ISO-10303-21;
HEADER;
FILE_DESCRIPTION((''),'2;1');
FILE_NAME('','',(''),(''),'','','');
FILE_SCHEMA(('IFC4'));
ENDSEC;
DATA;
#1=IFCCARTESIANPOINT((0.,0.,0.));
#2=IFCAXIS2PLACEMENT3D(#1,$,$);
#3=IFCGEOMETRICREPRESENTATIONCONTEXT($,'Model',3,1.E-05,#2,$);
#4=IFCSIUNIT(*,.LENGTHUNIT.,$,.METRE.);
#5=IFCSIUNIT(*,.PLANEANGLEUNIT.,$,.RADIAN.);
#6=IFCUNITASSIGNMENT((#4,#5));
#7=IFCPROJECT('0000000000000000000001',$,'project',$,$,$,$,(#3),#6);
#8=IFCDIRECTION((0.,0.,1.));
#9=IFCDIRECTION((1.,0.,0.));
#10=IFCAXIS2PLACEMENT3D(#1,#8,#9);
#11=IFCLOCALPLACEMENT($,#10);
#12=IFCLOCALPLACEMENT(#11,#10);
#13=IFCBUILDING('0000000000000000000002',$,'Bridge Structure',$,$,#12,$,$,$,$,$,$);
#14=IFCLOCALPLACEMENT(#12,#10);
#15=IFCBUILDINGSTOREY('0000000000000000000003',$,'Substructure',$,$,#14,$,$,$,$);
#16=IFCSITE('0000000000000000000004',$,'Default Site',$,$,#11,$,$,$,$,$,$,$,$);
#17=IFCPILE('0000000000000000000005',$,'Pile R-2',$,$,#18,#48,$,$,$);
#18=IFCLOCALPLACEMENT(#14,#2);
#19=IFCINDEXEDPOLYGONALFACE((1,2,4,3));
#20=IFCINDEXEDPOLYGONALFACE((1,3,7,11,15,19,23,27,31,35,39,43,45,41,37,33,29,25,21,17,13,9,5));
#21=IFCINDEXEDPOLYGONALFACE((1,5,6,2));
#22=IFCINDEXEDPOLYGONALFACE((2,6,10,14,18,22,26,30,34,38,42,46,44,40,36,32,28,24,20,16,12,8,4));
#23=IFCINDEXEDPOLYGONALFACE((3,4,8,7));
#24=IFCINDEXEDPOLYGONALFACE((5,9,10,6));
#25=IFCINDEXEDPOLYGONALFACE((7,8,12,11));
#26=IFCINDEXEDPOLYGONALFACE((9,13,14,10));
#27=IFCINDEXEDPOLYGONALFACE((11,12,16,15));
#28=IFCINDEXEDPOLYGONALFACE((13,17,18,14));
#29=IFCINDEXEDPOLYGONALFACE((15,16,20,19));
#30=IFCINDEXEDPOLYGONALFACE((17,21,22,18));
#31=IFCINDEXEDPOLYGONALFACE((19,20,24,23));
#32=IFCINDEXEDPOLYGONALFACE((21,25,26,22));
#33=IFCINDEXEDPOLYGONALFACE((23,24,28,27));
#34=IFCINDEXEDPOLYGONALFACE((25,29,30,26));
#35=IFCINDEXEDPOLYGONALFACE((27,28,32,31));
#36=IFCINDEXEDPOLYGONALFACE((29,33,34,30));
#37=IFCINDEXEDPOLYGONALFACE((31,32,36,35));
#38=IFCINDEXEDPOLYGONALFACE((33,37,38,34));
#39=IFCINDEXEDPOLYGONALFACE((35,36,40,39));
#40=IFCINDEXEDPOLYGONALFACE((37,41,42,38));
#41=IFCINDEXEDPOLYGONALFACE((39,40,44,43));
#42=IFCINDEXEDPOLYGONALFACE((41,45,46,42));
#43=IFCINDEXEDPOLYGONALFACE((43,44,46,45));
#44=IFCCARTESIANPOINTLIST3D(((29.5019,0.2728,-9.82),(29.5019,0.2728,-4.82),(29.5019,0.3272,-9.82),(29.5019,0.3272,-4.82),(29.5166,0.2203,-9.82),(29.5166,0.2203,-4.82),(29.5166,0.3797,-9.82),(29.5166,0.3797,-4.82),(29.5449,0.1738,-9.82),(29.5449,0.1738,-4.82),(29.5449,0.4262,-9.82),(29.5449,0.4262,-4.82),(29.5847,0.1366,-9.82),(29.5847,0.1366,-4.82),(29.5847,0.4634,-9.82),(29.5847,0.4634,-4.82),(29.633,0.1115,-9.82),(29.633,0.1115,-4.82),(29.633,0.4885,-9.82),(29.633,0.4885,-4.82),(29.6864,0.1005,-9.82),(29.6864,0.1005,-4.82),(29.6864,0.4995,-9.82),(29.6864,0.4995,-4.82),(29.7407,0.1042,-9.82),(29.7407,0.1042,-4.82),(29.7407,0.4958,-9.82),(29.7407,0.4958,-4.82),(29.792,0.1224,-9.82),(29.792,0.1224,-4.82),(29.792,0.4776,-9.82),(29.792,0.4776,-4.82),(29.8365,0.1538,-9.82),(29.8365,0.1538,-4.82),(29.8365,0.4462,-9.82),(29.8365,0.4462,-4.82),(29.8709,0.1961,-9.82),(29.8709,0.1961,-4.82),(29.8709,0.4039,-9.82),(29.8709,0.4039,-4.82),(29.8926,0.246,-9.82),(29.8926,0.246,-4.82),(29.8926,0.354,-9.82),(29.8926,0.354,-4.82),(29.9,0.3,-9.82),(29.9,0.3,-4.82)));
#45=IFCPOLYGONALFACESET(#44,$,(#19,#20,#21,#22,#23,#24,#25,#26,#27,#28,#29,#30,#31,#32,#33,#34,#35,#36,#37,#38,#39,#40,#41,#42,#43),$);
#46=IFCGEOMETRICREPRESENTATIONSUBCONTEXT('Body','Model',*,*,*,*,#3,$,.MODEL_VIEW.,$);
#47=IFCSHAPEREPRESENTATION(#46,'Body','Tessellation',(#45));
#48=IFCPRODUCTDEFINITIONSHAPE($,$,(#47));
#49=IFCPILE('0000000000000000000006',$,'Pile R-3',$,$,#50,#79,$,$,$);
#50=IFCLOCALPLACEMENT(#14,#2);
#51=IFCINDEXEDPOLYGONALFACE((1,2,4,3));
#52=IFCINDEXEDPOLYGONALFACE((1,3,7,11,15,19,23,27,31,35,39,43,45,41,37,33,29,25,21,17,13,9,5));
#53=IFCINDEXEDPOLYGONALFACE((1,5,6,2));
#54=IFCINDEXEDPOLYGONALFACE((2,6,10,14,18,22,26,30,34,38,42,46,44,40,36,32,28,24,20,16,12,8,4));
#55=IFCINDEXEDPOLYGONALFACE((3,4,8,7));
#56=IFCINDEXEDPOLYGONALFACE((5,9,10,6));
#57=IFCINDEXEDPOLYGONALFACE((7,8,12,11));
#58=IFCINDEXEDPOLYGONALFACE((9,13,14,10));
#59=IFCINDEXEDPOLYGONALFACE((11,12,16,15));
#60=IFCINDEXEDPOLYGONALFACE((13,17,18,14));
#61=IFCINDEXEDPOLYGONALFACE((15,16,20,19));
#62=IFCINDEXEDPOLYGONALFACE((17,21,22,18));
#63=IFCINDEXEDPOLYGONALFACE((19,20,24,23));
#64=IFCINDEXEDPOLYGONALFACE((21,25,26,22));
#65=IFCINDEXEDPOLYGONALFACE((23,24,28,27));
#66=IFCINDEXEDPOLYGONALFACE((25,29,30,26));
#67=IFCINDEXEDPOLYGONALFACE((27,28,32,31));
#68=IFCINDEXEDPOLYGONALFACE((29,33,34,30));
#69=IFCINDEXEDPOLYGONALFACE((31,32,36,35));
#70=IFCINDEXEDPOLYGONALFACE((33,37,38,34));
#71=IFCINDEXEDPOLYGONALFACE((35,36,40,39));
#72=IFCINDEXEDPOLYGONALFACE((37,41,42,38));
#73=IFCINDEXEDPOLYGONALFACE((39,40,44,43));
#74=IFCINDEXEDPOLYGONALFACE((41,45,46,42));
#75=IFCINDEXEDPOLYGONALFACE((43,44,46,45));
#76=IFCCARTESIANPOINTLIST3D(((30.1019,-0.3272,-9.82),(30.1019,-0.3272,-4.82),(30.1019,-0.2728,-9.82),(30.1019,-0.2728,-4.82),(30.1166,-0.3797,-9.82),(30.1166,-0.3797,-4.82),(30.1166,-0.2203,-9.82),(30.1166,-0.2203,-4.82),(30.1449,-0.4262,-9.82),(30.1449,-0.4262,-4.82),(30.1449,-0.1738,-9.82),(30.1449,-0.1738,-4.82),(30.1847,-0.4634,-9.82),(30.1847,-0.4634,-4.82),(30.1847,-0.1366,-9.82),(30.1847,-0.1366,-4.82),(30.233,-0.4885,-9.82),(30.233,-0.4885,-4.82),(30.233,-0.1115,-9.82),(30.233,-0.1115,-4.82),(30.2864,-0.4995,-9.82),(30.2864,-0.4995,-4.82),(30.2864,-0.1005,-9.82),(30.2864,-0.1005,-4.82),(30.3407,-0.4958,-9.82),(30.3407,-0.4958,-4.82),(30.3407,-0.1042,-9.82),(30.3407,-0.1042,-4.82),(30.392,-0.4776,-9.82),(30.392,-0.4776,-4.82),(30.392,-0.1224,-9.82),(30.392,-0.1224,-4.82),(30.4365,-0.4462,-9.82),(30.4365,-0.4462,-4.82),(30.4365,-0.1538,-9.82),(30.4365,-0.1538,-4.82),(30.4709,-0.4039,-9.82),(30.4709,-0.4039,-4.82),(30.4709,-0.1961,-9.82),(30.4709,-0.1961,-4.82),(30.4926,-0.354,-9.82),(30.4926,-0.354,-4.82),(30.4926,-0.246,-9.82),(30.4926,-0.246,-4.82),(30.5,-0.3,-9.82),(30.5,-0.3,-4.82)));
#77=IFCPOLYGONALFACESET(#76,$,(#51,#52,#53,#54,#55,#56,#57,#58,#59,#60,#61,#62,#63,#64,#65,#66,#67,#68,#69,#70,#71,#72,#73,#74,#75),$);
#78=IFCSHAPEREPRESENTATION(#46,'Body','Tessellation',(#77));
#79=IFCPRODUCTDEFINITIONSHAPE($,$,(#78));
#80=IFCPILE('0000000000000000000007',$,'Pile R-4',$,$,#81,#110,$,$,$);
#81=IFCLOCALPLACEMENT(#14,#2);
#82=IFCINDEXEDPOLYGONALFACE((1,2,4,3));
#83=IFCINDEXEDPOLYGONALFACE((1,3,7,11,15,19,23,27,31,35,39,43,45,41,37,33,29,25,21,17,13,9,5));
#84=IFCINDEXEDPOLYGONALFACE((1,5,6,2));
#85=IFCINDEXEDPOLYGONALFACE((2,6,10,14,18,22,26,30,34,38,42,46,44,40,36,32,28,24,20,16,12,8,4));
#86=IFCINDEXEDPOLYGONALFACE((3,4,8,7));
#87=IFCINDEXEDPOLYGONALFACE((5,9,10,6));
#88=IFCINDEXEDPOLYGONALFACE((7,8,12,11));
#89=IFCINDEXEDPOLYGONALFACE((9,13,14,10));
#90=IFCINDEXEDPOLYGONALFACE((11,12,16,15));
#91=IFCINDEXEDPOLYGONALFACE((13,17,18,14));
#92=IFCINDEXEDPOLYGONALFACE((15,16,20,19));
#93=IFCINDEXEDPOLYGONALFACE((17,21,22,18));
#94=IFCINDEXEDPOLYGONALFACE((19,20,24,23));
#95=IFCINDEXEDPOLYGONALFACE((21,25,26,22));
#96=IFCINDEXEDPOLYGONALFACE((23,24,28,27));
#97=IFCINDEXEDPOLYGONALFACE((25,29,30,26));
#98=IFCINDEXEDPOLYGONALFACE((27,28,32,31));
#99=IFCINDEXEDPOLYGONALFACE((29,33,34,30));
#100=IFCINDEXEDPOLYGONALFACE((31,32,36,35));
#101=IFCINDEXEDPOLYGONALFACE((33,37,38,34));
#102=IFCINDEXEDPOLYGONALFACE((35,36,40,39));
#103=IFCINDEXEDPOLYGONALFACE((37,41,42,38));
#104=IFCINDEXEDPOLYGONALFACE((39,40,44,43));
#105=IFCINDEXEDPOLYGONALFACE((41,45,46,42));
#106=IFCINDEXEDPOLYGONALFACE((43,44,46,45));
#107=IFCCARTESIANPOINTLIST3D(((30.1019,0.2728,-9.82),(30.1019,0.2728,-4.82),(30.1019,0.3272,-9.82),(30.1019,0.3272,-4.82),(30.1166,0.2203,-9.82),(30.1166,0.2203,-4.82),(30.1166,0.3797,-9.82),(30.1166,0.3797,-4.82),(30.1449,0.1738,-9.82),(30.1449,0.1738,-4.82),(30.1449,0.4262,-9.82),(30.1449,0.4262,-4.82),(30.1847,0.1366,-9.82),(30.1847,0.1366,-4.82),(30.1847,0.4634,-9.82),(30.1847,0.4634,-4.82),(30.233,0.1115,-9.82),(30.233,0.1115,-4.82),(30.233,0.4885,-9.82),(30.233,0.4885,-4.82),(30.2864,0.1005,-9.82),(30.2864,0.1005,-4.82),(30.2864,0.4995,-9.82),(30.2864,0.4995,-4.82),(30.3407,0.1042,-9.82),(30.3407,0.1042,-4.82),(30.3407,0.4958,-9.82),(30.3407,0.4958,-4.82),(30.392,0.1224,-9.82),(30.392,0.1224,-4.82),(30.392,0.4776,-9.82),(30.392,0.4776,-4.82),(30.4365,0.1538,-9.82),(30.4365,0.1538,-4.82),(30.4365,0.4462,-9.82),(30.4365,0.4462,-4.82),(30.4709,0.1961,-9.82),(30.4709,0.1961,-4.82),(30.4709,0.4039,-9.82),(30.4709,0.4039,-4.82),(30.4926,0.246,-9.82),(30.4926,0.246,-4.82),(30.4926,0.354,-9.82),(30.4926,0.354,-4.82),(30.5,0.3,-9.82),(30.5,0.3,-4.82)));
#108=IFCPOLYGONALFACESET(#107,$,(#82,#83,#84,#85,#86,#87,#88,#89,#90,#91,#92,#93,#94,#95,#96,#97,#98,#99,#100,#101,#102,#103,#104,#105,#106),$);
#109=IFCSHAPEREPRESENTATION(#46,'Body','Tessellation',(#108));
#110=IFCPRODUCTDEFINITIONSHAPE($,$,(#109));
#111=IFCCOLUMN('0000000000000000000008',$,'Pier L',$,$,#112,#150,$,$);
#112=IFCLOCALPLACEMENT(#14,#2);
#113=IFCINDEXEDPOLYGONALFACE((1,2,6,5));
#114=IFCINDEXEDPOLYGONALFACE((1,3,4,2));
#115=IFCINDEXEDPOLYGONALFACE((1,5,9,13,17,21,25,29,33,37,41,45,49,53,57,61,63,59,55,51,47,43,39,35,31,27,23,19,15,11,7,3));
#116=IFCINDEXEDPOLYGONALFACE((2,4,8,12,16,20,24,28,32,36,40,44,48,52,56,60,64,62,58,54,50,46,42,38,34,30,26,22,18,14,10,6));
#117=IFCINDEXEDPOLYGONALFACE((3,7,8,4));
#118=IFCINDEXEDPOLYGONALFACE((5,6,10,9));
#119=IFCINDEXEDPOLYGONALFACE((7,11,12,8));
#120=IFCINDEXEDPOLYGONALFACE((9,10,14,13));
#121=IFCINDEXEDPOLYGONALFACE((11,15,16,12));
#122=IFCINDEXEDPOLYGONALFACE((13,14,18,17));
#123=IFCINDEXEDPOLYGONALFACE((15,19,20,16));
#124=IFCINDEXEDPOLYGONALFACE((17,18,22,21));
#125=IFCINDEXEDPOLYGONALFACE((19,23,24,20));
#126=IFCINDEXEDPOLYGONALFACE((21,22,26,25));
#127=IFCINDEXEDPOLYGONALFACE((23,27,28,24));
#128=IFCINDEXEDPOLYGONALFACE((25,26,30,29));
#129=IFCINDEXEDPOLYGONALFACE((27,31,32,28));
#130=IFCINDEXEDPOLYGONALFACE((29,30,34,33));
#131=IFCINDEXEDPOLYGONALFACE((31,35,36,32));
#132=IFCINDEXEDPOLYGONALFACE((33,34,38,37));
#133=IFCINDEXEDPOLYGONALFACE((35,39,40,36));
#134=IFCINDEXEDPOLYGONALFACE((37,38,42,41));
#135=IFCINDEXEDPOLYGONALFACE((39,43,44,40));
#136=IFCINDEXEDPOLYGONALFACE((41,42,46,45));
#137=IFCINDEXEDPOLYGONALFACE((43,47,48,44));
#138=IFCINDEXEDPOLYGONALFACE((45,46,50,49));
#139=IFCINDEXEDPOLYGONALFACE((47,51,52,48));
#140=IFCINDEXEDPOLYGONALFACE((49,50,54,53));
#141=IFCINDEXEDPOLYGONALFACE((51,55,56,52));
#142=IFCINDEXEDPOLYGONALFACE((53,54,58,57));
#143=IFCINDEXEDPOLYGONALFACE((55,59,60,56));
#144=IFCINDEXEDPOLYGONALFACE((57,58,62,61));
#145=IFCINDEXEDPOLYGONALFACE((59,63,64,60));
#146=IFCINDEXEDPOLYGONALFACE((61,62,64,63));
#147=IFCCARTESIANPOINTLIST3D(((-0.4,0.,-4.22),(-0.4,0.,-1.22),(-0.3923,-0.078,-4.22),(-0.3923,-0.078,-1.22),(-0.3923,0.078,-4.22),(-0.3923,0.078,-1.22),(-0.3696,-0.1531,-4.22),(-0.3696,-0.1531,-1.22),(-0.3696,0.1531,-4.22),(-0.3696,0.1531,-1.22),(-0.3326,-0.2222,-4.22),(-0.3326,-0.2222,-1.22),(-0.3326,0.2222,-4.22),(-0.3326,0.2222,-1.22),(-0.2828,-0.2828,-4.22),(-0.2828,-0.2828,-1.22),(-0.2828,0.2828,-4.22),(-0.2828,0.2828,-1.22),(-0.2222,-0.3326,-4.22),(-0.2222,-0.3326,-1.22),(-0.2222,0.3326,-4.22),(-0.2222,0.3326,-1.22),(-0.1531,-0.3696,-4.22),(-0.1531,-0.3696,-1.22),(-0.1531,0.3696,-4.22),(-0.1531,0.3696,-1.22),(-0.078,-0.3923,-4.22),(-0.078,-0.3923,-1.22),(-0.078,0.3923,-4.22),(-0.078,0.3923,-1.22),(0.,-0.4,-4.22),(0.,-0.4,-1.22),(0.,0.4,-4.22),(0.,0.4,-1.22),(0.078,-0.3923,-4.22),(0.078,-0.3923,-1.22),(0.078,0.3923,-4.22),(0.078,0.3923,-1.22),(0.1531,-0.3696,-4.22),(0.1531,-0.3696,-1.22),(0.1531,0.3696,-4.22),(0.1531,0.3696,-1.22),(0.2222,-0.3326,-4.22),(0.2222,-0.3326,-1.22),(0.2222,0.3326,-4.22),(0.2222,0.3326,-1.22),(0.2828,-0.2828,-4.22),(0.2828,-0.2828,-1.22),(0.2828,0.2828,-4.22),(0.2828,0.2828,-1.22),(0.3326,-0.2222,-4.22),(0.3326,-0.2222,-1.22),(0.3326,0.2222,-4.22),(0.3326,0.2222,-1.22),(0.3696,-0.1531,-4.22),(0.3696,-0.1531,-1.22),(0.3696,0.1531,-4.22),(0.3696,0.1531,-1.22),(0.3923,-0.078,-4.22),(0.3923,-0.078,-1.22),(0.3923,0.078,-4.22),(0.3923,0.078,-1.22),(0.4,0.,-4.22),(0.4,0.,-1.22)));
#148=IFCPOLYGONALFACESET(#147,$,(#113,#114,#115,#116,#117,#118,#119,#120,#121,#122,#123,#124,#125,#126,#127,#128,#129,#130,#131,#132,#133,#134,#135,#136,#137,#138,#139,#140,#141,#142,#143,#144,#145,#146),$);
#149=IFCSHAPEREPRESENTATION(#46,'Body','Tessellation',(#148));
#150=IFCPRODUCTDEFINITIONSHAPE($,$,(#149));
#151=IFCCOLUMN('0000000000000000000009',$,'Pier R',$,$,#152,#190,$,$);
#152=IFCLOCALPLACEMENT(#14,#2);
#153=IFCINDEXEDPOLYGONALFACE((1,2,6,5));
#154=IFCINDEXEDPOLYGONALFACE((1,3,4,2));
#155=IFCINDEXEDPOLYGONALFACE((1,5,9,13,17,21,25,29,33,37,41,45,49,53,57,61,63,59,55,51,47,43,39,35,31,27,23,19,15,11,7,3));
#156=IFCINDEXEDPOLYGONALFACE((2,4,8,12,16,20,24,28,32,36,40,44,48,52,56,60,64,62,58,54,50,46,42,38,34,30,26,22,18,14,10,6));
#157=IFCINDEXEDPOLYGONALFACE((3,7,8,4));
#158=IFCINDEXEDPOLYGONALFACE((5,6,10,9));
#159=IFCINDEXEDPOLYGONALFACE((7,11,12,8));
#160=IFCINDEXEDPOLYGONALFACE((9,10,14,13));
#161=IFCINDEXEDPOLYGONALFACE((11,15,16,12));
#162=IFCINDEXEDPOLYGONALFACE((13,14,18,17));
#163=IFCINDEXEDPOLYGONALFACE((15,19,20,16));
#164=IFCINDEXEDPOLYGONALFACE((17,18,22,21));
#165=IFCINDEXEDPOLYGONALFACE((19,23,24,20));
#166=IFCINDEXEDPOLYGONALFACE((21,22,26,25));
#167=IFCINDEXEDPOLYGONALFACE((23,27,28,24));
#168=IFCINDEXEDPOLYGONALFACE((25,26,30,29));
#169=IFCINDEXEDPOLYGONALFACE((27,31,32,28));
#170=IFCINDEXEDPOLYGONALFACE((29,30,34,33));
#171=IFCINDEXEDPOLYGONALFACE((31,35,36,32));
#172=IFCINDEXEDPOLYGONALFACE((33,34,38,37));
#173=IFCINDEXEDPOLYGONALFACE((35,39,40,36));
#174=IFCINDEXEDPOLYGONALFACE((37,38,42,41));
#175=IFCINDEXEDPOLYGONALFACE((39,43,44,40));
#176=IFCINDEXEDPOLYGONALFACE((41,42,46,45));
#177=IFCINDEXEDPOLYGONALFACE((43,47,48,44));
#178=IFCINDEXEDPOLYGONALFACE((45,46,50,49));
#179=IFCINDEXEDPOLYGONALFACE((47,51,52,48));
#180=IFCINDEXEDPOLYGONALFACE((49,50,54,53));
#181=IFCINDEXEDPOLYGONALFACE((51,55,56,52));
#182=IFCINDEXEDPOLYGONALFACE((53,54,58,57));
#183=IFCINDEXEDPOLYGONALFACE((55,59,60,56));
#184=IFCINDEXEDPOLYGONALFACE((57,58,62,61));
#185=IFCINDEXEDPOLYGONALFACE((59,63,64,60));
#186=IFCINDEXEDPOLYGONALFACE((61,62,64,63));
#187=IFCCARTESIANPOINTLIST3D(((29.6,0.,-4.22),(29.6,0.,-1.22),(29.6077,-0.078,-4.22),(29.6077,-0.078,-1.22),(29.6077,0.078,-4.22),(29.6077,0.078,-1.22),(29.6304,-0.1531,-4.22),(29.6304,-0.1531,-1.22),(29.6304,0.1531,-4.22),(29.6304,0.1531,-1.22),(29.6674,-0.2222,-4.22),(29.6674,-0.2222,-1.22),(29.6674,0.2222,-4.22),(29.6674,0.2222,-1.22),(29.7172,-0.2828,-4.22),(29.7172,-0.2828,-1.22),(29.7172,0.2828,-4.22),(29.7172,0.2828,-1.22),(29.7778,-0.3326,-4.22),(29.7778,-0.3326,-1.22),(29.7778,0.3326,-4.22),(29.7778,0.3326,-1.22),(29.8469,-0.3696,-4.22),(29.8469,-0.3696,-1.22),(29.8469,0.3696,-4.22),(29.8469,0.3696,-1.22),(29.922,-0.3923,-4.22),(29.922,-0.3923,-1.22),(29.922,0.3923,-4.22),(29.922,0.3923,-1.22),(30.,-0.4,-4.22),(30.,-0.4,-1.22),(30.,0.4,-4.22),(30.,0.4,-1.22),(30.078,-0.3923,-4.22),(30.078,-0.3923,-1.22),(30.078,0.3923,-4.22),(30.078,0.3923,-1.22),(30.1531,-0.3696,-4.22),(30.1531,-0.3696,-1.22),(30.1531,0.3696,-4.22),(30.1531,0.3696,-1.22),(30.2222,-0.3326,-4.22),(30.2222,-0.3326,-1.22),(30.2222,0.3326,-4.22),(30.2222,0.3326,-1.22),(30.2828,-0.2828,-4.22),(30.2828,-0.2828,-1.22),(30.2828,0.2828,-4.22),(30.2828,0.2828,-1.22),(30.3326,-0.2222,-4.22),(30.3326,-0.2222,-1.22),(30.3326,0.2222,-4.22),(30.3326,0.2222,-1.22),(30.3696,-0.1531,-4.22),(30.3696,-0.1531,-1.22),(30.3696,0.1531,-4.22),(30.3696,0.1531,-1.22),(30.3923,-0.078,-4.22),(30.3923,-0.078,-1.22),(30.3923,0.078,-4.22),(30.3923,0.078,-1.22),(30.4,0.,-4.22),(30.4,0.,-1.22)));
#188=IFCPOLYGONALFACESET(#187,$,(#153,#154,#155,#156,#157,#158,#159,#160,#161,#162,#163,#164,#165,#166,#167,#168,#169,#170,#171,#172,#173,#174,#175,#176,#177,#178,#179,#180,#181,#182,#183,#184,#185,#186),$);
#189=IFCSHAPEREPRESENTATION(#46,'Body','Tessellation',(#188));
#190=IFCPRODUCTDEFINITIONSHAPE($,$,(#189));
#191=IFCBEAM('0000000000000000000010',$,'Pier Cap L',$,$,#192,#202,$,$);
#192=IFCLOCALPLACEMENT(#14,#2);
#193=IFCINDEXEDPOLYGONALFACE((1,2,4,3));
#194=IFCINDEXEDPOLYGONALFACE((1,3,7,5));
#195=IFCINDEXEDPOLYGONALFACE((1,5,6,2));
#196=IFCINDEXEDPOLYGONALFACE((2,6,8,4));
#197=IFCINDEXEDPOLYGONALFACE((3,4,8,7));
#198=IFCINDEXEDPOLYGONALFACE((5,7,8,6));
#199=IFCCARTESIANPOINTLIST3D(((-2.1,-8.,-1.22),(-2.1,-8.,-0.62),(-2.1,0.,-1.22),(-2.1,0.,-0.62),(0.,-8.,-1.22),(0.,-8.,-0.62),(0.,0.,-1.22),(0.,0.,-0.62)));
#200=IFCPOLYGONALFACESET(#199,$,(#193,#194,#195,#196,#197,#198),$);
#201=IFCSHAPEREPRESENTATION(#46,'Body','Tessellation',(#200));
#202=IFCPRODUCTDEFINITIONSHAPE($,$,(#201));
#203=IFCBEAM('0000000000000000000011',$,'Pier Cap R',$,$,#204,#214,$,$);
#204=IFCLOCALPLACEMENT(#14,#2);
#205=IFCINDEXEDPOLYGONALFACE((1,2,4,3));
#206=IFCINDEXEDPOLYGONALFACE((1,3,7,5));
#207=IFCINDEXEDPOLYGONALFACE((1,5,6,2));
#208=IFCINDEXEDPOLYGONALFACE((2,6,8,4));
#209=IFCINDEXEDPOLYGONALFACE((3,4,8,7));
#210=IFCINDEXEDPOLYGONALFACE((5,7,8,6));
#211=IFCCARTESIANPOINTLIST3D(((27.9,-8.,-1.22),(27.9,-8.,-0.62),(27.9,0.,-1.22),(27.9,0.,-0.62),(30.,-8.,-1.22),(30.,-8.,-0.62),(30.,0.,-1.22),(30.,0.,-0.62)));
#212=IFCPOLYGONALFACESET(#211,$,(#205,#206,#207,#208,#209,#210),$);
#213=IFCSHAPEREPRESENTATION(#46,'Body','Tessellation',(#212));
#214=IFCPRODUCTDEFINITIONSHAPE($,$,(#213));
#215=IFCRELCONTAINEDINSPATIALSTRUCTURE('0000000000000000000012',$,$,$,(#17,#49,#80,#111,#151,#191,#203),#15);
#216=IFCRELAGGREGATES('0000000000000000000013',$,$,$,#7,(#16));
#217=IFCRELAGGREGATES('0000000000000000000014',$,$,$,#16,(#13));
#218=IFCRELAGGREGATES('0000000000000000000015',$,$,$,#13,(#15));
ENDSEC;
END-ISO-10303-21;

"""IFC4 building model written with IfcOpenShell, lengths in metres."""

from ifc_helpers import new_model, si_unit, frame, origin, origin_with_axes, origin_2d_with_axis, place, context, subcontext, project, spatial, rectangle, circle, extrude, element, save


model = new_model("IFC4")

# Units and contexts
model_context = context("Model", 3, precision=1e-05, world=origin())
body_context = subcontext(model_context, "Body", "Model", "MODEL_VIEW")
ifc_project = project(units=[si_unit("LENGTHUNIT", "METRE"), si_unit("PLANEANGLEUNIT", "RADIAN")], contexts=[model_context])

# Site, building, storey
site_placement = place(None, origin_with_axes())
site = spatial("IfcSite", under=ifc_project, at=site_placement, Name="Default Site")
building_placement = place(site_placement, origin_with_axes())
building = spatial("IfcBuilding", under=site, at=building_placement, Name="Bridge Structure")
storey_placement = place(building_placement, origin_with_axes())
storey = spatial("IfcBuildingStorey", under=building, at=storey_placement, Name="Substructure")

# Piles
for number, where, z_axis, x_axis, name in (
    (1, (29.7, 0.3, -9.82), (0.0, 0.0, 1.0), (1.0, 0.0, 0.0), "Pile R-2"),
    (2, (30.3, -0.3, -9.82), (0.0, 0.0, 1.0), (1.0, 0.0, 0.0), "Pile R-3"),
    (3, (30.3, 0.3, -9.82), (0.0, 0.0, 1.0), (1.0, 0.0, 0.0), "Pile R-4"),
):
    element("IfcPile", number, at=place(storey_placement, frame(where, z_axis=z_axis, x_axis=x_axis)), inside=storey, Name=name, context=body_context, shape_type="SweptSolid", body=[
        extrude(circle(Radius=0.2, at=origin_2d_with_axis()), origin_with_axes(), (0.0, 0.0, 1.0), 5.0),
    ])

# Columns
for number, where, z_axis, x_axis, name in (
    (4, (0.0, 0.0, -4.22), (0.0, 0.0, 1.0), (1.0, 0.0, 0.0), "Pier L"),
    (5, (30.0, 0.0, -4.22), (0.0, 0.0, 1.0), (1.0, 0.0, 0.0), "Pier R"),
):
    element("IfcColumn", number, at=place(storey_placement, frame(where, z_axis=z_axis, x_axis=x_axis)), inside=storey, Name=name, context=body_context, shape_type="SweptSolid", body=[
        extrude(circle(Radius=0.4, at=origin_2d_with_axis()), origin_with_axes(), (0.0, 0.0, 1.0), 3.0),
    ])

# Beams
for number, where, z_axis, x_axis, name in (
    (6, (-1.05, -4.0, -1.22), (0.0, 0.0, 1.0), (1.0, 0.0, 0.0), "Pier Cap L"),
    (7, (28.95, -4.0, -1.22), (0.0, 0.0, 1.0), (1.0, 0.0, 0.0), "Pier Cap R"),
):
    element("IfcBeam", number, at=place(storey_placement, frame(where, z_axis=z_axis, x_axis=x_axis)), inside=storey, Name=name, context=body_context, shape_type="SweptSolid", body=[
        extrude(rectangle(XDim=2.1, YDim=8.0, at=origin_2d_with_axis()), origin_with_axes(), (0.0, 0.0, 1.0), 0.6),
    ])

save(model, "model.ifc")
